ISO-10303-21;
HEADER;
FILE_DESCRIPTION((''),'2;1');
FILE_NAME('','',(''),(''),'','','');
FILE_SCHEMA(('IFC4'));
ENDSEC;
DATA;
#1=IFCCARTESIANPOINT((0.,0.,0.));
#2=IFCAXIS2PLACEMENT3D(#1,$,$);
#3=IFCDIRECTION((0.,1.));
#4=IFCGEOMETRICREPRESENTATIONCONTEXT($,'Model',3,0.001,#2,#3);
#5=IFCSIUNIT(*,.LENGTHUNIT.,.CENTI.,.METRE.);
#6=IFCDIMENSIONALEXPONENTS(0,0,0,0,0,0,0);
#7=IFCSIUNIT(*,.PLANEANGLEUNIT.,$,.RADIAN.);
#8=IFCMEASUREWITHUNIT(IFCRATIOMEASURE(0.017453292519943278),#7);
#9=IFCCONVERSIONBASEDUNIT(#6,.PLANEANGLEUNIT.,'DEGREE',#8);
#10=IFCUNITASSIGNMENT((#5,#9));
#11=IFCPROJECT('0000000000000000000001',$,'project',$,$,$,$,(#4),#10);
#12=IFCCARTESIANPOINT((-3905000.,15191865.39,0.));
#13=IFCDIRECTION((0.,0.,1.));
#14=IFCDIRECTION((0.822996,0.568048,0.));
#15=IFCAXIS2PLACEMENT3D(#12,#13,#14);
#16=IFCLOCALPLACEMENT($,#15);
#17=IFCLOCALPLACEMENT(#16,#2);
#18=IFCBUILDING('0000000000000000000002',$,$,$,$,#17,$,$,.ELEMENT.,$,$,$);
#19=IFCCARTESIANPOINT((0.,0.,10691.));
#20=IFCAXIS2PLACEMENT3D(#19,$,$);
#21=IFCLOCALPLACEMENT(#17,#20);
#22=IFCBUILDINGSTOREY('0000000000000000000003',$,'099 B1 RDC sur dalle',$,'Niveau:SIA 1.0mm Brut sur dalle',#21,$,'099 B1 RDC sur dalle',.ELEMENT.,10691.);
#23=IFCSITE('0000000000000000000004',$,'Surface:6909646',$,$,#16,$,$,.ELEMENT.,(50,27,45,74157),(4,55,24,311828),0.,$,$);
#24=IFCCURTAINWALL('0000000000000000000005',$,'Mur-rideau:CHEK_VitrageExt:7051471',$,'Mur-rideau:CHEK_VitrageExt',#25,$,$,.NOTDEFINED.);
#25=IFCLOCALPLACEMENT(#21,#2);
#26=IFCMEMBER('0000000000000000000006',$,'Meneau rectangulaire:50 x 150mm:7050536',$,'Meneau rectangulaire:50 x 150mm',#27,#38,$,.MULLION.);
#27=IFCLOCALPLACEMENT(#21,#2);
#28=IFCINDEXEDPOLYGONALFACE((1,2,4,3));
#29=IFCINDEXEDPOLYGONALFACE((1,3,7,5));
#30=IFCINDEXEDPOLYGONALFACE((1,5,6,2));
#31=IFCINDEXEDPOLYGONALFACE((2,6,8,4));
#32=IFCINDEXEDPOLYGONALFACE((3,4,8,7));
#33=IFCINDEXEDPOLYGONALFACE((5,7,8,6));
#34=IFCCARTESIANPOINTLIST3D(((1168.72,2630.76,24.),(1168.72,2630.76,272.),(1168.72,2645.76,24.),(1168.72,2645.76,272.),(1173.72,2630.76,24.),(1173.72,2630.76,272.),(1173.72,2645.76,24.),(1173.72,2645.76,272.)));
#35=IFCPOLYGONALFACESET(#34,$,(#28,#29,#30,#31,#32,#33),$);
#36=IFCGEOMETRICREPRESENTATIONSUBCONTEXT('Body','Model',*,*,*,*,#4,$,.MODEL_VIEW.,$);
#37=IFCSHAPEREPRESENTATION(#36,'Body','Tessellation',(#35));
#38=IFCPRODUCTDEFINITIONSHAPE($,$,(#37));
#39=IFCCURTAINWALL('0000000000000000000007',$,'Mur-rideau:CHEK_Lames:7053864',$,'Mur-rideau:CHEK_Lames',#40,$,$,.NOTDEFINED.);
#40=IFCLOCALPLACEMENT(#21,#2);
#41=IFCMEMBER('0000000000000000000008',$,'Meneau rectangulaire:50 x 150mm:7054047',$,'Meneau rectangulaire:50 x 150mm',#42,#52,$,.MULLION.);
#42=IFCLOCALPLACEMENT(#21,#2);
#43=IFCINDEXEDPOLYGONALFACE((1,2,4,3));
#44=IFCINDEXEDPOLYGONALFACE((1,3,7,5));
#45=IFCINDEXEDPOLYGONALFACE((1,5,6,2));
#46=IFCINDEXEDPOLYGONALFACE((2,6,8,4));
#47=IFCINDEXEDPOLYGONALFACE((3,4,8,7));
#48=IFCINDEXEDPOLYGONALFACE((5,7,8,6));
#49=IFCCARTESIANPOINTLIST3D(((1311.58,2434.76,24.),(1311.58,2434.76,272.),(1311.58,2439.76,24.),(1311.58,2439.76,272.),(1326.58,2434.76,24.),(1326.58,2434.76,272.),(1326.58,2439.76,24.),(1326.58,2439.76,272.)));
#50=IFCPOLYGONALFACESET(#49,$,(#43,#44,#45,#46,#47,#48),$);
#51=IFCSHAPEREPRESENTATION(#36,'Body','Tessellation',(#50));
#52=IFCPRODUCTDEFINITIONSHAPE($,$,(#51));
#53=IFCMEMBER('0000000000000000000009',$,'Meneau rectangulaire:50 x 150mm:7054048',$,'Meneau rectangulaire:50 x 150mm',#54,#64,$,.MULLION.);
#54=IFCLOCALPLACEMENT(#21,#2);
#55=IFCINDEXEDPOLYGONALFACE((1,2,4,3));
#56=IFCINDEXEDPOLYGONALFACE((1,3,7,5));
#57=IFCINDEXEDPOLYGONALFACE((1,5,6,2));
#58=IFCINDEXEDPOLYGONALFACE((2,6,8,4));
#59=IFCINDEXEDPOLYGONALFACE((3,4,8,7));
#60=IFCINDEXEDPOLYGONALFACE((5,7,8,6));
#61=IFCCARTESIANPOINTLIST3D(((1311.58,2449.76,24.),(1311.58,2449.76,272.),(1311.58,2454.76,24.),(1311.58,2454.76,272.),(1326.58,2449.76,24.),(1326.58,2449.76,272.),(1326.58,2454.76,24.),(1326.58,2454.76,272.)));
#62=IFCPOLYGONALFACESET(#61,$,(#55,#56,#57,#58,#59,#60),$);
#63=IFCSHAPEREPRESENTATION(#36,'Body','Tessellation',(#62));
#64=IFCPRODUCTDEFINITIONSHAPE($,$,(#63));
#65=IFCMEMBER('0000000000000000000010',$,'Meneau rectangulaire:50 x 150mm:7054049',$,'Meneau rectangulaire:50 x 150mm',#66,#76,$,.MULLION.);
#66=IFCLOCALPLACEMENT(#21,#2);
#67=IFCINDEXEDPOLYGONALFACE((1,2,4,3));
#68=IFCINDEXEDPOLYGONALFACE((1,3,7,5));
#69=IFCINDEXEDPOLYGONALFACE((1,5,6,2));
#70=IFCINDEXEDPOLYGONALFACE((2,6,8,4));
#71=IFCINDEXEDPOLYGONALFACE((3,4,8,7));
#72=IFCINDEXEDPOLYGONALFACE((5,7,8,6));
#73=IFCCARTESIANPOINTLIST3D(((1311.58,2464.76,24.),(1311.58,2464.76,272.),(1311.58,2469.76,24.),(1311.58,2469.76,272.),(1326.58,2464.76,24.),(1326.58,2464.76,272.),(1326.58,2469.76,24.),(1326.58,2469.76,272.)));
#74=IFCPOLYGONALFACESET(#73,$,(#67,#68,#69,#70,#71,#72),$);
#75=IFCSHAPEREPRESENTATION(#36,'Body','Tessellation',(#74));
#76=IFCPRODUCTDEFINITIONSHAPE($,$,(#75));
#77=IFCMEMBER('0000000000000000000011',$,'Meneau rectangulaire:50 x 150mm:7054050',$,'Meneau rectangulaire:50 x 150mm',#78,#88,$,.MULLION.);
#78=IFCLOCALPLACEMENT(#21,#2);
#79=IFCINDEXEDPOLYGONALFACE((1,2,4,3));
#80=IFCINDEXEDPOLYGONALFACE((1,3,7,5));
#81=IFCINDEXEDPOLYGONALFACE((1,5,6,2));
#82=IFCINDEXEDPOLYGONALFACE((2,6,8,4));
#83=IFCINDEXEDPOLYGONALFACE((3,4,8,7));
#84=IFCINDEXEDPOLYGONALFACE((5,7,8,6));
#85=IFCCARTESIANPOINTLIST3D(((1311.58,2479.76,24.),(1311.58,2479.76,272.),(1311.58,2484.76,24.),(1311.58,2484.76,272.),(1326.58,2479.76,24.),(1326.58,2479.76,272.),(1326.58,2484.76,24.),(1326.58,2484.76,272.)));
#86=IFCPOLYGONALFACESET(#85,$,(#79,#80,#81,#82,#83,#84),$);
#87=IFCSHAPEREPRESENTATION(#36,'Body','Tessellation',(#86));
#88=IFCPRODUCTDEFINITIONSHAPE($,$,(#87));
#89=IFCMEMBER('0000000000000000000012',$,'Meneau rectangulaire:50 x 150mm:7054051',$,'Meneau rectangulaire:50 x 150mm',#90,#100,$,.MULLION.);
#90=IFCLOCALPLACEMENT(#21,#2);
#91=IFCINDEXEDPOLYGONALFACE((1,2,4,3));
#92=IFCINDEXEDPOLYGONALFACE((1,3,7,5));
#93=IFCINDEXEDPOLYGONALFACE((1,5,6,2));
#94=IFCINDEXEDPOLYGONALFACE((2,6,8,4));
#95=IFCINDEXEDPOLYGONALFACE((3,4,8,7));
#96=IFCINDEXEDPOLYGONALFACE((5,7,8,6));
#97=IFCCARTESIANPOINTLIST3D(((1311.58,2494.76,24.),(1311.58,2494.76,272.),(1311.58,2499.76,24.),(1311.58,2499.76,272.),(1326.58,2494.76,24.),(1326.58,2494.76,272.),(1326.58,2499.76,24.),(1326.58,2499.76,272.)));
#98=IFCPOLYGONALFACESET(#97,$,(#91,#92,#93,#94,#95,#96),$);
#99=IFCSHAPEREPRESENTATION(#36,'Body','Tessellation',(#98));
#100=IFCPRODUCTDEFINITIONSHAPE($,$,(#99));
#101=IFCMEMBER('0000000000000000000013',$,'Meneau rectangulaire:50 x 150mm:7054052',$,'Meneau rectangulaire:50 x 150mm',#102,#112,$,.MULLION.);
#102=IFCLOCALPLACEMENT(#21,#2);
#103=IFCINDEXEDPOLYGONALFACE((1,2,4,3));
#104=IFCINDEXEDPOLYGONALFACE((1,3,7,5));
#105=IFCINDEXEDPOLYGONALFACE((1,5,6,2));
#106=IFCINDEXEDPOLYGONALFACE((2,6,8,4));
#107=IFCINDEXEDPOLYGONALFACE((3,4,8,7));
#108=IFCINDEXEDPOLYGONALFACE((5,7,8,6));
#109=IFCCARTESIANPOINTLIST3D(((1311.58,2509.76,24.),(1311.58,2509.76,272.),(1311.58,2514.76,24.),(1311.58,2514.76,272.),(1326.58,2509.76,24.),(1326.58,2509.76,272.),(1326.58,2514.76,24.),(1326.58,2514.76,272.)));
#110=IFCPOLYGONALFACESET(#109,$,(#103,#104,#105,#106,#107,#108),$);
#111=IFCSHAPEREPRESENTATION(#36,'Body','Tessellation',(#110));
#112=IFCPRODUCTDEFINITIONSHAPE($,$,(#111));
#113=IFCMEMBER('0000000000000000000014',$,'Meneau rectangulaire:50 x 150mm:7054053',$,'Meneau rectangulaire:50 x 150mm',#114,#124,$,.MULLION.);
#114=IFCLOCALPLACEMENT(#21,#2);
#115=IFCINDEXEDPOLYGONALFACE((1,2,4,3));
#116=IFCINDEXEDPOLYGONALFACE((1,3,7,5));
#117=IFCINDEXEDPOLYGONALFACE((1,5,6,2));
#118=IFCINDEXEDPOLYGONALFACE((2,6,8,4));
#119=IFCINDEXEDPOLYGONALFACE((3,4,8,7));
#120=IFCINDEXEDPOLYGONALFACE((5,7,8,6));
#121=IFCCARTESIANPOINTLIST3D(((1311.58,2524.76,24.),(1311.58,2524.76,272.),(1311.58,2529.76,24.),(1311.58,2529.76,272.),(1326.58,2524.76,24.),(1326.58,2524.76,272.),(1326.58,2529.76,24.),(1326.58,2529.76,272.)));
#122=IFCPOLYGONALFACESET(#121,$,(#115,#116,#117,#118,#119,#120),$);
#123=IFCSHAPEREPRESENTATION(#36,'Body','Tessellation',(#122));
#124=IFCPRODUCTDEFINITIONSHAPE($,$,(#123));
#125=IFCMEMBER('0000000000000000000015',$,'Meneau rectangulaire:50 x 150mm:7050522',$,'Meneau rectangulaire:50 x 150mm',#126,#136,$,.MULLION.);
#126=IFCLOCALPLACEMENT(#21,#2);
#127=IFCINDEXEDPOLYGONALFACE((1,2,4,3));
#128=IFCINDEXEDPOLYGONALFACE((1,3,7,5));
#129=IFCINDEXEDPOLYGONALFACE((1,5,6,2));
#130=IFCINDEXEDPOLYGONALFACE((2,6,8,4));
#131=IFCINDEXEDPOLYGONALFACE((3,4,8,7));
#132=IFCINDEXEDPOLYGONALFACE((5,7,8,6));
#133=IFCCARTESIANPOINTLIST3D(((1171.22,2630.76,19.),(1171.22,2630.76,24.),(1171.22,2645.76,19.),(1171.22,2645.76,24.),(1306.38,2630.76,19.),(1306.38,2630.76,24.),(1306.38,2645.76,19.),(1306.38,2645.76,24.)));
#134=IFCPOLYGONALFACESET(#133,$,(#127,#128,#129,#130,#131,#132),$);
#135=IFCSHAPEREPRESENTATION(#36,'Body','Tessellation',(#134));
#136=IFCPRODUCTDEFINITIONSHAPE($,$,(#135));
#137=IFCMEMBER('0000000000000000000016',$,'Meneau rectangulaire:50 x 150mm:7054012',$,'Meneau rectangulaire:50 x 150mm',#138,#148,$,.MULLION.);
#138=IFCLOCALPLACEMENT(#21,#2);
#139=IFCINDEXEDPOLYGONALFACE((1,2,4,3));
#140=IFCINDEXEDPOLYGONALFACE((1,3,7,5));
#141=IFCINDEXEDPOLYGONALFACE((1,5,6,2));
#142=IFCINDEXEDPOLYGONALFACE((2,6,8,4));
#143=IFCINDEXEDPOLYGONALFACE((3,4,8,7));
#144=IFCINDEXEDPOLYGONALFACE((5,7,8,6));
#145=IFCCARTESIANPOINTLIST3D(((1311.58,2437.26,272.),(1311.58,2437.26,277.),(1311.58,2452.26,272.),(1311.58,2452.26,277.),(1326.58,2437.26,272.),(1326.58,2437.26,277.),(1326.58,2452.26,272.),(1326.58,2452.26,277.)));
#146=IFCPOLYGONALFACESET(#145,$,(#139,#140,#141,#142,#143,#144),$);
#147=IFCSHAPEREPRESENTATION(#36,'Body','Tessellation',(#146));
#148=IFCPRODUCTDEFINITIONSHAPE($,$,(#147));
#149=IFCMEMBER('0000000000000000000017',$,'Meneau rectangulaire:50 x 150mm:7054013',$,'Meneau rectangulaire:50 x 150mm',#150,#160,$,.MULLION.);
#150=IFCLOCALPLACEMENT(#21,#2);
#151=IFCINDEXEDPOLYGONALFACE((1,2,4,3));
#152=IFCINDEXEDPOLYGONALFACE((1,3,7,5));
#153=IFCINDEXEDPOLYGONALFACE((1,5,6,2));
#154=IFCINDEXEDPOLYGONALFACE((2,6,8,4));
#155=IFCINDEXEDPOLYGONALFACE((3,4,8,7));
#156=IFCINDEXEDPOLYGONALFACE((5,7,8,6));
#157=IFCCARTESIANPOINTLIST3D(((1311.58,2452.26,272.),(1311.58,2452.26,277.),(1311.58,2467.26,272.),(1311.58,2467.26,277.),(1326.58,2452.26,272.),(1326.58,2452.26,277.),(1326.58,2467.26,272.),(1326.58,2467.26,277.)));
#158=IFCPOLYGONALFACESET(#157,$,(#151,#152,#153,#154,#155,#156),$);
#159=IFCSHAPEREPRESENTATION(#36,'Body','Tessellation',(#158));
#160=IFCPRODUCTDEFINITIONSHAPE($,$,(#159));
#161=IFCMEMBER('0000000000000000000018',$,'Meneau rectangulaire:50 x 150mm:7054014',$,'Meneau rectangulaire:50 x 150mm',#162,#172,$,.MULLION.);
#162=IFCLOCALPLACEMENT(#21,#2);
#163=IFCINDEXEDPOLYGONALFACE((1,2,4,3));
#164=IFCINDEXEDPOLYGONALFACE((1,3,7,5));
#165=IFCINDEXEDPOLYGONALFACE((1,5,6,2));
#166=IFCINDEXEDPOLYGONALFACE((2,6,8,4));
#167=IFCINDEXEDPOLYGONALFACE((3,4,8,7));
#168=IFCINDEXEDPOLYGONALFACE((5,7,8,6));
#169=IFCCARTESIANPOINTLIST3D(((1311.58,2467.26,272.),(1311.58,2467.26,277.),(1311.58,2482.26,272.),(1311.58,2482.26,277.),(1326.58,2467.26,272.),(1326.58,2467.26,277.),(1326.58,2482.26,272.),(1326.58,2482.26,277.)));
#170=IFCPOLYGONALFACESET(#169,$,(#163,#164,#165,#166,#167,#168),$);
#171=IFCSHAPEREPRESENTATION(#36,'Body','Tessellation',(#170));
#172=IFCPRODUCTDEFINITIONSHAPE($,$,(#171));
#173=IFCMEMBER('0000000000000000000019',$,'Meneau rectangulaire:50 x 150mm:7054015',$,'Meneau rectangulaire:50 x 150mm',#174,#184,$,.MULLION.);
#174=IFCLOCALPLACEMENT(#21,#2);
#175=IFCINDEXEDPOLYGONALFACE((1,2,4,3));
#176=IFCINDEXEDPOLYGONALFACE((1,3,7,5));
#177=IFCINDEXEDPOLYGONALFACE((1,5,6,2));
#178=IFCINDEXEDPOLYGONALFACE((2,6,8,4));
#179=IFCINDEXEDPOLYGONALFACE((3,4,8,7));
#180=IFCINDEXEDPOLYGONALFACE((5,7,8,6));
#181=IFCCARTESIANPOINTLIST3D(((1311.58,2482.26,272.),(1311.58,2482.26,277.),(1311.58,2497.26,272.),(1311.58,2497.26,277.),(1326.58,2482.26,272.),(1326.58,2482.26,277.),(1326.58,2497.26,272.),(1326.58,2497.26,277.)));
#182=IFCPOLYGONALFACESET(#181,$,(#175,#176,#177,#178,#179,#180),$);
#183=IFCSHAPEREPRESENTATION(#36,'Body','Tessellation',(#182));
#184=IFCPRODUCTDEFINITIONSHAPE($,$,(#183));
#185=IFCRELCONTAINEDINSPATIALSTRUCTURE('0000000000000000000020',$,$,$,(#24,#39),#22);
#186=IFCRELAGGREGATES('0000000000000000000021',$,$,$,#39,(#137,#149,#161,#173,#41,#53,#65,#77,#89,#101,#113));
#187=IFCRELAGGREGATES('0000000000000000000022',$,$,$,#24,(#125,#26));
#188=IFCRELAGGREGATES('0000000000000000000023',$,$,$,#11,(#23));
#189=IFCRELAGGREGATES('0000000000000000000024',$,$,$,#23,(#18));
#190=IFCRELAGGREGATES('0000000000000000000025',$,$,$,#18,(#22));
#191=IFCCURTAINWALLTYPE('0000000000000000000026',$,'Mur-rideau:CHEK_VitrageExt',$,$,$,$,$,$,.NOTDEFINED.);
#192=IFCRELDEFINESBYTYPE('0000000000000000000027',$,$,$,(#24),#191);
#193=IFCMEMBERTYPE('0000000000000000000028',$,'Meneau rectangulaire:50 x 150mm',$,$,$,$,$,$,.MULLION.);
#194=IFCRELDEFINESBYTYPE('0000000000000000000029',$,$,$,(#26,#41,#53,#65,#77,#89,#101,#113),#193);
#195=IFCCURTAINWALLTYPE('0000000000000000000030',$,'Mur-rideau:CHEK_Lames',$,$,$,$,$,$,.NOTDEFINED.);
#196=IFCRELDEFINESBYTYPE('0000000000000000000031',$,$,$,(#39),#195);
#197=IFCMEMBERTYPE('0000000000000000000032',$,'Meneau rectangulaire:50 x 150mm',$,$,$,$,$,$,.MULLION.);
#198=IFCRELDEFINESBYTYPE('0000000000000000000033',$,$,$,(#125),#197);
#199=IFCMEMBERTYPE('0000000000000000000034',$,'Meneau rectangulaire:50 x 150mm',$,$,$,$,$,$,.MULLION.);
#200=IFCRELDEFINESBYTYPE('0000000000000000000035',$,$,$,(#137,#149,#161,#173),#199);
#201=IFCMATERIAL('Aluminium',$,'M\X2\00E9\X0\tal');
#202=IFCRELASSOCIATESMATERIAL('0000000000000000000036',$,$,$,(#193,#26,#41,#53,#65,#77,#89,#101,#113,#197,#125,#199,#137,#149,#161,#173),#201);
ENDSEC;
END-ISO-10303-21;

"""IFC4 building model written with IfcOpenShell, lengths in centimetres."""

from ifc_helpers import new_model, entity, si_unit, converted_unit, direction, frame, origin, place, context, subcontext, project, spatial, indexed_curve, outline, extrude, source, transform, mapped, material, type_object, type_shapes, element, aggregate, save


model = new_model("IFC4")

# Units and contexts
model_context = context("Model", 3, precision=0.001, world=origin(), true_north=direction((0.0, 1.0)))
body_context = subcontext(model_context, "Body", "Model", "MODEL_VIEW")
ifc_project = project(units=[si_unit("LENGTHUNIT", "METRE", prefix="CENTI"), converted_unit("PLANEANGLEUNIT", "DEGREE", entity("IfcRatioMeasure", 0.017453292519943278), si_unit("PLANEANGLEUNIT", "RADIAN"), dimensions=[0, 0, 0, 0, 0, 0, 0])], contexts=[model_context])

# Site, building, storey
site_placement = place(None, frame((-3905000.0, 15191865.39, 0.0), z_axis=(0.0, 0.0, 1.0), x_axis=(0.822996, 0.568048, 0.0)))
site = spatial("IfcSite", under=ifc_project, at=site_placement, Name="Surface:6909646", CompositionType="ELEMENT", RefLatitude=(50, 27, 45, 74157), RefLongitude=(4, 55, 24, 311828), RefElevation=0.0)
building_placement = place(site_placement, origin())
building = spatial("IfcBuilding", under=site, at=building_placement, CompositionType="ELEMENT")
storey_placement = place(building_placement, frame((0.0, 0.0, 10691.0)))
storey = spatial("IfcBuildingStorey", under=building, at=storey_placement, Name="099 B1 RDC sur dalle", ObjectType="Niveau:SIA 1.0mm Brut sur dalle", LongName="099 B1 RDC sur dalle", CompositionType="ELEMENT", Elevation=10691.0)

# Curtain wall, member
curtain_wall_type_1 = type_object("IfcCurtainWallType", Name="Mur-rideau:CHEK_VitrageExt", PredefinedType="NOTDEFINED")
curtain_wall_1_placement = place(storey_placement, frame((0.0, 0.0, -10691.0)))
curtain_wall_1 = element("IfcCurtainWall", 1, at=curtain_wall_1_placement, inside=storey, type_object=curtain_wall_type_1, Name="Mur-rideau:CHEK_VitrageExt:7051471", ObjectType="Mur-rideau:CHEK_VitrageExt", PredefinedType="NOTDEFINED")
ifc_material_1 = material(Name="Aluminium", Category="Métal")
member_type_1 = type_object("IfcMemberType", Name="Meneau rectangulaire:50 x 150mm", PredefinedType="MULLION", material=ifc_material_1)
shared_shape_1 = source(origin(), body_context, "Body", "SweptSolid", [
    extrude(outline(indexed_curve([(-7.5, -2.5), (7.5, -2.5), (7.5, 2.5), (-7.5, 2.5), (-7.5, -2.5)], self_intersect=False)), frame((0.0, -6.0, -248.0), z_axis=(0.0, 0.0, 1.0), x_axis=(0.0, -1.0, 0.0)), (0.0, 0.0, 1.0), 248.0),
])
type_shapes(member_type_1, [shared_shape_1])
member_1_placement = place(curtain_wall_1_placement, frame((1171.22, 2632.26, 10715.0), z_axis=(0.0, 0.0, -1.0), x_axis=(1.0, 0.0, 0.0)))
member_1 = element("IfcMember", 2, at=member_1_placement, type_object=member_type_1, material=ifc_material_1, Name="Meneau rectangulaire:50 x 150mm:7050536", ObjectType="Meneau rectangulaire:50 x 150mm", PredefinedType="MULLION", context=body_context, shape_type="MappedRepresentation", body=[
    mapped(shared_shape_1, transform((0.0, 0.0, 0.0), scale=1.0)),
])

# Curtain wall, members
curtain_wall_type_2 = type_object("IfcCurtainWallType", Name="Mur-rideau:CHEK_Lames", PredefinedType="NOTDEFINED")
curtain_wall_2_placement = place(storey_placement, frame((0.0, 0.0, -10691.0)))
curtain_wall_2 = element("IfcCurtainWall", 3, at=curtain_wall_2_placement, inside=storey, type_object=curtain_wall_type_2, Name="Mur-rideau:CHEK_Lames:7053864", ObjectType="Mur-rideau:CHEK_Lames", PredefinedType="NOTDEFINED")
member_2_placement = place(curtain_wall_2_placement, frame((1325.08, 2437.26, 10715.0), z_axis=(0.0, 0.0, -1.0), x_axis=(0.0, 1.0, 0.0)))
member_2 = element("IfcMember", 4, at=member_2_placement, type_object=member_type_1, material=ifc_material_1, Name="Meneau rectangulaire:50 x 150mm:7054047", ObjectType="Meneau rectangulaire:50 x 150mm", PredefinedType="MULLION", context=body_context, shape_type="MappedRepresentation", body=[
    mapped(shared_shape_1, transform((0.0, 0.0, 0.0), scale=1.0)),
])
member_3_placement = place(curtain_wall_2_placement, frame((1325.08, 2452.26, 10715.0), z_axis=(0.0, 0.0, -1.0), x_axis=(0.0, 1.0, 0.0)))
member_3 = element("IfcMember", 5, at=member_3_placement, type_object=member_type_1, material=ifc_material_1, Name="Meneau rectangulaire:50 x 150mm:7054048", ObjectType="Meneau rectangulaire:50 x 150mm", PredefinedType="MULLION", context=body_context, shape_type="MappedRepresentation", body=[
    mapped(shared_shape_1, transform((0.0, 0.0, 0.0), scale=1.0)),
])
member_4_placement = place(curtain_wall_2_placement, frame((1325.08, 2467.26, 10715.0), z_axis=(0.0, 0.0, -1.0), x_axis=(0.0, 1.0, 0.0)))
member_4 = element("IfcMember", 6, at=member_4_placement, type_object=member_type_1, material=ifc_material_1, Name="Meneau rectangulaire:50 x 150mm:7054049", ObjectType="Meneau rectangulaire:50 x 150mm", PredefinedType="MULLION", context=body_context, shape_type="MappedRepresentation", body=[
    mapped(shared_shape_1, transform((0.0, 0.0, 0.0), scale=1.0)),
])
member_5_placement = place(curtain_wall_2_placement, frame((1325.08, 2482.26, 10715.0), z_axis=(0.0, 0.0, -1.0), x_axis=(0.0, 1.0, 0.0)))
member_5 = element("IfcMember", 7, at=member_5_placement, type_object=member_type_1, material=ifc_material_1, Name="Meneau rectangulaire:50 x 150mm:7054050", ObjectType="Meneau rectangulaire:50 x 150mm", PredefinedType="MULLION", context=body_context, shape_type="MappedRepresentation", body=[
    mapped(shared_shape_1, transform((0.0, 0.0, 0.0), scale=1.0)),
])
member_6_placement = place(curtain_wall_2_placement, frame((1325.08, 2497.26, 10715.0), z_axis=(0.0, 0.0, -1.0), x_axis=(0.0, 1.0, 0.0)))
member_6 = element("IfcMember", 8, at=member_6_placement, type_object=member_type_1, material=ifc_material_1, Name="Meneau rectangulaire:50 x 150mm:7054051", ObjectType="Meneau rectangulaire:50 x 150mm", PredefinedType="MULLION", context=body_context, shape_type="MappedRepresentation", body=[
    mapped(shared_shape_1, transform((0.0, 0.0, 0.0), scale=1.0)),
])
member_7_placement = place(curtain_wall_2_placement, frame((1325.08, 2512.26, 10715.0), z_axis=(0.0, 0.0, -1.0), x_axis=(0.0, 1.0, 0.0)))
member_7 = element("IfcMember", 9, at=member_7_placement, type_object=member_type_1, material=ifc_material_1, Name="Meneau rectangulaire:50 x 150mm:7054052", ObjectType="Meneau rectangulaire:50 x 150mm", PredefinedType="MULLION", context=body_context, shape_type="MappedRepresentation", body=[
    mapped(shared_shape_1, transform((0.0, 0.0, 0.0), scale=1.0)),
])
member_8_placement = place(curtain_wall_2_placement, frame((1325.08, 2527.26, 10715.0), z_axis=(0.0, 0.0, -1.0), x_axis=(0.0, 1.0, 0.0)))
member_8 = element("IfcMember", 10, at=member_8_placement, type_object=member_type_1, material=ifc_material_1, Name="Meneau rectangulaire:50 x 150mm:7054053", ObjectType="Meneau rectangulaire:50 x 150mm", PredefinedType="MULLION", context=body_context, shape_type="MappedRepresentation", body=[
    mapped(shared_shape_1, transform((0.0, 0.0, 0.0), scale=1.0)),
])

# Members
member_type_2 = type_object("IfcMemberType", Name="Meneau rectangulaire:50 x 150mm", PredefinedType="MULLION", material=ifc_material_1)
shared_shape_2 = source(origin(), body_context, "Body", "SweptSolid", [
    extrude(outline(indexed_curve([(-7.5, -2.5), (7.5, -2.5), (7.5, 2.5), (-7.5, 2.5), (-7.5, -2.5)], self_intersect=False)), frame((-2.5, -6.0, -135.15), z_axis=(0.0, 0.0, 1.0), x_axis=(0.0, -1.0, 0.0)), (0.0, 0.0, 1.0), 135.15),
])
type_shapes(member_type_2, [shared_shape_2])
member_9_placement = place(curtain_wall_1_placement, frame((1171.22, 2632.26, 10710.0), z_axis=(-1.0, 0.0, 0.0), x_axis=(0.0, 0.0, -1.0)))
member_9 = element("IfcMember", 11, at=member_9_placement, type_object=member_type_2, material=ifc_material_1, Name="Meneau rectangulaire:50 x 150mm:7050522", ObjectType="Meneau rectangulaire:50 x 150mm", PredefinedType="MULLION", context=body_context, shape_type="MappedRepresentation", body=[
    mapped(shared_shape_2, transform((0.0, 0.0, 0.0), scale=1.0)),
])
member_type_3 = type_object("IfcMemberType", Name="Meneau rectangulaire:50 x 150mm", PredefinedType="MULLION", material=ifc_material_1)
shared_shape_3 = source(origin(), body_context, "Body", "SweptSolid", [
    extrude(outline(indexed_curve([(-7.5, -2.5), (7.5, -2.5), (7.5, 2.5), (-7.5, 2.5), (-7.5, -2.5)], self_intersect=False)), frame((-2.5, -6.0, -15.0), z_axis=(0.0, 0.0, 1.0), x_axis=(0.0, -1.0, 0.0)), (0.0, 0.0, 1.0), 15.0),
])
type_shapes(member_type_3, [shared_shape_3])
member_10_placement = place(curtain_wall_2_placement, frame((1325.08, 2452.26, 10968.0), z_axis=(0.0, 1.0, 0.0), x_axis=(0.0, 0.0, 1.0)))
member_10 = element("IfcMember", 12, at=member_10_placement, type_object=member_type_3, material=ifc_material_1, Name="Meneau rectangulaire:50 x 150mm:7054012", ObjectType="Meneau rectangulaire:50 x 150mm", PredefinedType="MULLION", context=body_context, shape_type="MappedRepresentation", body=[
    mapped(shared_shape_3, transform((0.0, 0.0, 0.0), scale=1.0)),
])
member_11_placement = place(curtain_wall_2_placement, frame((1325.08, 2467.26, 10968.0), z_axis=(0.0, 1.0, 0.0), x_axis=(0.0, 0.0, 1.0)))
member_11 = element("IfcMember", 13, at=member_11_placement, type_object=member_type_3, material=ifc_material_1, Name="Meneau rectangulaire:50 x 150mm:7054013", ObjectType="Meneau rectangulaire:50 x 150mm", PredefinedType="MULLION", context=body_context, shape_type="MappedRepresentation", body=[
    mapped(shared_shape_3, transform((0.0, 0.0, 0.0), scale=1.0)),
])
member_12_placement = place(curtain_wall_2_placement, frame((1325.08, 2482.26, 10968.0), z_axis=(0.0, 1.0, 0.0), x_axis=(0.0, 0.0, 1.0)))
member_12 = element("IfcMember", 14, at=member_12_placement, type_object=member_type_3, material=ifc_material_1, Name="Meneau rectangulaire:50 x 150mm:7054014", ObjectType="Meneau rectangulaire:50 x 150mm", PredefinedType="MULLION", context=body_context, shape_type="MappedRepresentation", body=[
    mapped(shared_shape_3, transform((0.0, 0.0, 0.0), scale=1.0)),
])
member_13_placement = place(curtain_wall_2_placement, frame((1325.08, 2497.26, 10968.0), z_axis=(0.0, 1.0, 0.0), x_axis=(0.0, 0.0, 1.0)))
member_13 = element("IfcMember", 15, at=member_13_placement, type_object=member_type_3, material=ifc_material_1, Name="Meneau rectangulaire:50 x 150mm:7054015", ObjectType="Meneau rectangulaire:50 x 150mm", PredefinedType="MULLION", context=body_context, shape_type="MappedRepresentation", body=[
    mapped(shared_shape_3, transform((0.0, 0.0, 0.0), scale=1.0)),
])
aggregate(curtain_wall_2, [member_10, member_11, member_12, member_13, member_2, member_3, member_4, member_5, member_6, member_7, member_8])

aggregate(curtain_wall_1, [member_9, member_1])

save(model, "model.ifc")
